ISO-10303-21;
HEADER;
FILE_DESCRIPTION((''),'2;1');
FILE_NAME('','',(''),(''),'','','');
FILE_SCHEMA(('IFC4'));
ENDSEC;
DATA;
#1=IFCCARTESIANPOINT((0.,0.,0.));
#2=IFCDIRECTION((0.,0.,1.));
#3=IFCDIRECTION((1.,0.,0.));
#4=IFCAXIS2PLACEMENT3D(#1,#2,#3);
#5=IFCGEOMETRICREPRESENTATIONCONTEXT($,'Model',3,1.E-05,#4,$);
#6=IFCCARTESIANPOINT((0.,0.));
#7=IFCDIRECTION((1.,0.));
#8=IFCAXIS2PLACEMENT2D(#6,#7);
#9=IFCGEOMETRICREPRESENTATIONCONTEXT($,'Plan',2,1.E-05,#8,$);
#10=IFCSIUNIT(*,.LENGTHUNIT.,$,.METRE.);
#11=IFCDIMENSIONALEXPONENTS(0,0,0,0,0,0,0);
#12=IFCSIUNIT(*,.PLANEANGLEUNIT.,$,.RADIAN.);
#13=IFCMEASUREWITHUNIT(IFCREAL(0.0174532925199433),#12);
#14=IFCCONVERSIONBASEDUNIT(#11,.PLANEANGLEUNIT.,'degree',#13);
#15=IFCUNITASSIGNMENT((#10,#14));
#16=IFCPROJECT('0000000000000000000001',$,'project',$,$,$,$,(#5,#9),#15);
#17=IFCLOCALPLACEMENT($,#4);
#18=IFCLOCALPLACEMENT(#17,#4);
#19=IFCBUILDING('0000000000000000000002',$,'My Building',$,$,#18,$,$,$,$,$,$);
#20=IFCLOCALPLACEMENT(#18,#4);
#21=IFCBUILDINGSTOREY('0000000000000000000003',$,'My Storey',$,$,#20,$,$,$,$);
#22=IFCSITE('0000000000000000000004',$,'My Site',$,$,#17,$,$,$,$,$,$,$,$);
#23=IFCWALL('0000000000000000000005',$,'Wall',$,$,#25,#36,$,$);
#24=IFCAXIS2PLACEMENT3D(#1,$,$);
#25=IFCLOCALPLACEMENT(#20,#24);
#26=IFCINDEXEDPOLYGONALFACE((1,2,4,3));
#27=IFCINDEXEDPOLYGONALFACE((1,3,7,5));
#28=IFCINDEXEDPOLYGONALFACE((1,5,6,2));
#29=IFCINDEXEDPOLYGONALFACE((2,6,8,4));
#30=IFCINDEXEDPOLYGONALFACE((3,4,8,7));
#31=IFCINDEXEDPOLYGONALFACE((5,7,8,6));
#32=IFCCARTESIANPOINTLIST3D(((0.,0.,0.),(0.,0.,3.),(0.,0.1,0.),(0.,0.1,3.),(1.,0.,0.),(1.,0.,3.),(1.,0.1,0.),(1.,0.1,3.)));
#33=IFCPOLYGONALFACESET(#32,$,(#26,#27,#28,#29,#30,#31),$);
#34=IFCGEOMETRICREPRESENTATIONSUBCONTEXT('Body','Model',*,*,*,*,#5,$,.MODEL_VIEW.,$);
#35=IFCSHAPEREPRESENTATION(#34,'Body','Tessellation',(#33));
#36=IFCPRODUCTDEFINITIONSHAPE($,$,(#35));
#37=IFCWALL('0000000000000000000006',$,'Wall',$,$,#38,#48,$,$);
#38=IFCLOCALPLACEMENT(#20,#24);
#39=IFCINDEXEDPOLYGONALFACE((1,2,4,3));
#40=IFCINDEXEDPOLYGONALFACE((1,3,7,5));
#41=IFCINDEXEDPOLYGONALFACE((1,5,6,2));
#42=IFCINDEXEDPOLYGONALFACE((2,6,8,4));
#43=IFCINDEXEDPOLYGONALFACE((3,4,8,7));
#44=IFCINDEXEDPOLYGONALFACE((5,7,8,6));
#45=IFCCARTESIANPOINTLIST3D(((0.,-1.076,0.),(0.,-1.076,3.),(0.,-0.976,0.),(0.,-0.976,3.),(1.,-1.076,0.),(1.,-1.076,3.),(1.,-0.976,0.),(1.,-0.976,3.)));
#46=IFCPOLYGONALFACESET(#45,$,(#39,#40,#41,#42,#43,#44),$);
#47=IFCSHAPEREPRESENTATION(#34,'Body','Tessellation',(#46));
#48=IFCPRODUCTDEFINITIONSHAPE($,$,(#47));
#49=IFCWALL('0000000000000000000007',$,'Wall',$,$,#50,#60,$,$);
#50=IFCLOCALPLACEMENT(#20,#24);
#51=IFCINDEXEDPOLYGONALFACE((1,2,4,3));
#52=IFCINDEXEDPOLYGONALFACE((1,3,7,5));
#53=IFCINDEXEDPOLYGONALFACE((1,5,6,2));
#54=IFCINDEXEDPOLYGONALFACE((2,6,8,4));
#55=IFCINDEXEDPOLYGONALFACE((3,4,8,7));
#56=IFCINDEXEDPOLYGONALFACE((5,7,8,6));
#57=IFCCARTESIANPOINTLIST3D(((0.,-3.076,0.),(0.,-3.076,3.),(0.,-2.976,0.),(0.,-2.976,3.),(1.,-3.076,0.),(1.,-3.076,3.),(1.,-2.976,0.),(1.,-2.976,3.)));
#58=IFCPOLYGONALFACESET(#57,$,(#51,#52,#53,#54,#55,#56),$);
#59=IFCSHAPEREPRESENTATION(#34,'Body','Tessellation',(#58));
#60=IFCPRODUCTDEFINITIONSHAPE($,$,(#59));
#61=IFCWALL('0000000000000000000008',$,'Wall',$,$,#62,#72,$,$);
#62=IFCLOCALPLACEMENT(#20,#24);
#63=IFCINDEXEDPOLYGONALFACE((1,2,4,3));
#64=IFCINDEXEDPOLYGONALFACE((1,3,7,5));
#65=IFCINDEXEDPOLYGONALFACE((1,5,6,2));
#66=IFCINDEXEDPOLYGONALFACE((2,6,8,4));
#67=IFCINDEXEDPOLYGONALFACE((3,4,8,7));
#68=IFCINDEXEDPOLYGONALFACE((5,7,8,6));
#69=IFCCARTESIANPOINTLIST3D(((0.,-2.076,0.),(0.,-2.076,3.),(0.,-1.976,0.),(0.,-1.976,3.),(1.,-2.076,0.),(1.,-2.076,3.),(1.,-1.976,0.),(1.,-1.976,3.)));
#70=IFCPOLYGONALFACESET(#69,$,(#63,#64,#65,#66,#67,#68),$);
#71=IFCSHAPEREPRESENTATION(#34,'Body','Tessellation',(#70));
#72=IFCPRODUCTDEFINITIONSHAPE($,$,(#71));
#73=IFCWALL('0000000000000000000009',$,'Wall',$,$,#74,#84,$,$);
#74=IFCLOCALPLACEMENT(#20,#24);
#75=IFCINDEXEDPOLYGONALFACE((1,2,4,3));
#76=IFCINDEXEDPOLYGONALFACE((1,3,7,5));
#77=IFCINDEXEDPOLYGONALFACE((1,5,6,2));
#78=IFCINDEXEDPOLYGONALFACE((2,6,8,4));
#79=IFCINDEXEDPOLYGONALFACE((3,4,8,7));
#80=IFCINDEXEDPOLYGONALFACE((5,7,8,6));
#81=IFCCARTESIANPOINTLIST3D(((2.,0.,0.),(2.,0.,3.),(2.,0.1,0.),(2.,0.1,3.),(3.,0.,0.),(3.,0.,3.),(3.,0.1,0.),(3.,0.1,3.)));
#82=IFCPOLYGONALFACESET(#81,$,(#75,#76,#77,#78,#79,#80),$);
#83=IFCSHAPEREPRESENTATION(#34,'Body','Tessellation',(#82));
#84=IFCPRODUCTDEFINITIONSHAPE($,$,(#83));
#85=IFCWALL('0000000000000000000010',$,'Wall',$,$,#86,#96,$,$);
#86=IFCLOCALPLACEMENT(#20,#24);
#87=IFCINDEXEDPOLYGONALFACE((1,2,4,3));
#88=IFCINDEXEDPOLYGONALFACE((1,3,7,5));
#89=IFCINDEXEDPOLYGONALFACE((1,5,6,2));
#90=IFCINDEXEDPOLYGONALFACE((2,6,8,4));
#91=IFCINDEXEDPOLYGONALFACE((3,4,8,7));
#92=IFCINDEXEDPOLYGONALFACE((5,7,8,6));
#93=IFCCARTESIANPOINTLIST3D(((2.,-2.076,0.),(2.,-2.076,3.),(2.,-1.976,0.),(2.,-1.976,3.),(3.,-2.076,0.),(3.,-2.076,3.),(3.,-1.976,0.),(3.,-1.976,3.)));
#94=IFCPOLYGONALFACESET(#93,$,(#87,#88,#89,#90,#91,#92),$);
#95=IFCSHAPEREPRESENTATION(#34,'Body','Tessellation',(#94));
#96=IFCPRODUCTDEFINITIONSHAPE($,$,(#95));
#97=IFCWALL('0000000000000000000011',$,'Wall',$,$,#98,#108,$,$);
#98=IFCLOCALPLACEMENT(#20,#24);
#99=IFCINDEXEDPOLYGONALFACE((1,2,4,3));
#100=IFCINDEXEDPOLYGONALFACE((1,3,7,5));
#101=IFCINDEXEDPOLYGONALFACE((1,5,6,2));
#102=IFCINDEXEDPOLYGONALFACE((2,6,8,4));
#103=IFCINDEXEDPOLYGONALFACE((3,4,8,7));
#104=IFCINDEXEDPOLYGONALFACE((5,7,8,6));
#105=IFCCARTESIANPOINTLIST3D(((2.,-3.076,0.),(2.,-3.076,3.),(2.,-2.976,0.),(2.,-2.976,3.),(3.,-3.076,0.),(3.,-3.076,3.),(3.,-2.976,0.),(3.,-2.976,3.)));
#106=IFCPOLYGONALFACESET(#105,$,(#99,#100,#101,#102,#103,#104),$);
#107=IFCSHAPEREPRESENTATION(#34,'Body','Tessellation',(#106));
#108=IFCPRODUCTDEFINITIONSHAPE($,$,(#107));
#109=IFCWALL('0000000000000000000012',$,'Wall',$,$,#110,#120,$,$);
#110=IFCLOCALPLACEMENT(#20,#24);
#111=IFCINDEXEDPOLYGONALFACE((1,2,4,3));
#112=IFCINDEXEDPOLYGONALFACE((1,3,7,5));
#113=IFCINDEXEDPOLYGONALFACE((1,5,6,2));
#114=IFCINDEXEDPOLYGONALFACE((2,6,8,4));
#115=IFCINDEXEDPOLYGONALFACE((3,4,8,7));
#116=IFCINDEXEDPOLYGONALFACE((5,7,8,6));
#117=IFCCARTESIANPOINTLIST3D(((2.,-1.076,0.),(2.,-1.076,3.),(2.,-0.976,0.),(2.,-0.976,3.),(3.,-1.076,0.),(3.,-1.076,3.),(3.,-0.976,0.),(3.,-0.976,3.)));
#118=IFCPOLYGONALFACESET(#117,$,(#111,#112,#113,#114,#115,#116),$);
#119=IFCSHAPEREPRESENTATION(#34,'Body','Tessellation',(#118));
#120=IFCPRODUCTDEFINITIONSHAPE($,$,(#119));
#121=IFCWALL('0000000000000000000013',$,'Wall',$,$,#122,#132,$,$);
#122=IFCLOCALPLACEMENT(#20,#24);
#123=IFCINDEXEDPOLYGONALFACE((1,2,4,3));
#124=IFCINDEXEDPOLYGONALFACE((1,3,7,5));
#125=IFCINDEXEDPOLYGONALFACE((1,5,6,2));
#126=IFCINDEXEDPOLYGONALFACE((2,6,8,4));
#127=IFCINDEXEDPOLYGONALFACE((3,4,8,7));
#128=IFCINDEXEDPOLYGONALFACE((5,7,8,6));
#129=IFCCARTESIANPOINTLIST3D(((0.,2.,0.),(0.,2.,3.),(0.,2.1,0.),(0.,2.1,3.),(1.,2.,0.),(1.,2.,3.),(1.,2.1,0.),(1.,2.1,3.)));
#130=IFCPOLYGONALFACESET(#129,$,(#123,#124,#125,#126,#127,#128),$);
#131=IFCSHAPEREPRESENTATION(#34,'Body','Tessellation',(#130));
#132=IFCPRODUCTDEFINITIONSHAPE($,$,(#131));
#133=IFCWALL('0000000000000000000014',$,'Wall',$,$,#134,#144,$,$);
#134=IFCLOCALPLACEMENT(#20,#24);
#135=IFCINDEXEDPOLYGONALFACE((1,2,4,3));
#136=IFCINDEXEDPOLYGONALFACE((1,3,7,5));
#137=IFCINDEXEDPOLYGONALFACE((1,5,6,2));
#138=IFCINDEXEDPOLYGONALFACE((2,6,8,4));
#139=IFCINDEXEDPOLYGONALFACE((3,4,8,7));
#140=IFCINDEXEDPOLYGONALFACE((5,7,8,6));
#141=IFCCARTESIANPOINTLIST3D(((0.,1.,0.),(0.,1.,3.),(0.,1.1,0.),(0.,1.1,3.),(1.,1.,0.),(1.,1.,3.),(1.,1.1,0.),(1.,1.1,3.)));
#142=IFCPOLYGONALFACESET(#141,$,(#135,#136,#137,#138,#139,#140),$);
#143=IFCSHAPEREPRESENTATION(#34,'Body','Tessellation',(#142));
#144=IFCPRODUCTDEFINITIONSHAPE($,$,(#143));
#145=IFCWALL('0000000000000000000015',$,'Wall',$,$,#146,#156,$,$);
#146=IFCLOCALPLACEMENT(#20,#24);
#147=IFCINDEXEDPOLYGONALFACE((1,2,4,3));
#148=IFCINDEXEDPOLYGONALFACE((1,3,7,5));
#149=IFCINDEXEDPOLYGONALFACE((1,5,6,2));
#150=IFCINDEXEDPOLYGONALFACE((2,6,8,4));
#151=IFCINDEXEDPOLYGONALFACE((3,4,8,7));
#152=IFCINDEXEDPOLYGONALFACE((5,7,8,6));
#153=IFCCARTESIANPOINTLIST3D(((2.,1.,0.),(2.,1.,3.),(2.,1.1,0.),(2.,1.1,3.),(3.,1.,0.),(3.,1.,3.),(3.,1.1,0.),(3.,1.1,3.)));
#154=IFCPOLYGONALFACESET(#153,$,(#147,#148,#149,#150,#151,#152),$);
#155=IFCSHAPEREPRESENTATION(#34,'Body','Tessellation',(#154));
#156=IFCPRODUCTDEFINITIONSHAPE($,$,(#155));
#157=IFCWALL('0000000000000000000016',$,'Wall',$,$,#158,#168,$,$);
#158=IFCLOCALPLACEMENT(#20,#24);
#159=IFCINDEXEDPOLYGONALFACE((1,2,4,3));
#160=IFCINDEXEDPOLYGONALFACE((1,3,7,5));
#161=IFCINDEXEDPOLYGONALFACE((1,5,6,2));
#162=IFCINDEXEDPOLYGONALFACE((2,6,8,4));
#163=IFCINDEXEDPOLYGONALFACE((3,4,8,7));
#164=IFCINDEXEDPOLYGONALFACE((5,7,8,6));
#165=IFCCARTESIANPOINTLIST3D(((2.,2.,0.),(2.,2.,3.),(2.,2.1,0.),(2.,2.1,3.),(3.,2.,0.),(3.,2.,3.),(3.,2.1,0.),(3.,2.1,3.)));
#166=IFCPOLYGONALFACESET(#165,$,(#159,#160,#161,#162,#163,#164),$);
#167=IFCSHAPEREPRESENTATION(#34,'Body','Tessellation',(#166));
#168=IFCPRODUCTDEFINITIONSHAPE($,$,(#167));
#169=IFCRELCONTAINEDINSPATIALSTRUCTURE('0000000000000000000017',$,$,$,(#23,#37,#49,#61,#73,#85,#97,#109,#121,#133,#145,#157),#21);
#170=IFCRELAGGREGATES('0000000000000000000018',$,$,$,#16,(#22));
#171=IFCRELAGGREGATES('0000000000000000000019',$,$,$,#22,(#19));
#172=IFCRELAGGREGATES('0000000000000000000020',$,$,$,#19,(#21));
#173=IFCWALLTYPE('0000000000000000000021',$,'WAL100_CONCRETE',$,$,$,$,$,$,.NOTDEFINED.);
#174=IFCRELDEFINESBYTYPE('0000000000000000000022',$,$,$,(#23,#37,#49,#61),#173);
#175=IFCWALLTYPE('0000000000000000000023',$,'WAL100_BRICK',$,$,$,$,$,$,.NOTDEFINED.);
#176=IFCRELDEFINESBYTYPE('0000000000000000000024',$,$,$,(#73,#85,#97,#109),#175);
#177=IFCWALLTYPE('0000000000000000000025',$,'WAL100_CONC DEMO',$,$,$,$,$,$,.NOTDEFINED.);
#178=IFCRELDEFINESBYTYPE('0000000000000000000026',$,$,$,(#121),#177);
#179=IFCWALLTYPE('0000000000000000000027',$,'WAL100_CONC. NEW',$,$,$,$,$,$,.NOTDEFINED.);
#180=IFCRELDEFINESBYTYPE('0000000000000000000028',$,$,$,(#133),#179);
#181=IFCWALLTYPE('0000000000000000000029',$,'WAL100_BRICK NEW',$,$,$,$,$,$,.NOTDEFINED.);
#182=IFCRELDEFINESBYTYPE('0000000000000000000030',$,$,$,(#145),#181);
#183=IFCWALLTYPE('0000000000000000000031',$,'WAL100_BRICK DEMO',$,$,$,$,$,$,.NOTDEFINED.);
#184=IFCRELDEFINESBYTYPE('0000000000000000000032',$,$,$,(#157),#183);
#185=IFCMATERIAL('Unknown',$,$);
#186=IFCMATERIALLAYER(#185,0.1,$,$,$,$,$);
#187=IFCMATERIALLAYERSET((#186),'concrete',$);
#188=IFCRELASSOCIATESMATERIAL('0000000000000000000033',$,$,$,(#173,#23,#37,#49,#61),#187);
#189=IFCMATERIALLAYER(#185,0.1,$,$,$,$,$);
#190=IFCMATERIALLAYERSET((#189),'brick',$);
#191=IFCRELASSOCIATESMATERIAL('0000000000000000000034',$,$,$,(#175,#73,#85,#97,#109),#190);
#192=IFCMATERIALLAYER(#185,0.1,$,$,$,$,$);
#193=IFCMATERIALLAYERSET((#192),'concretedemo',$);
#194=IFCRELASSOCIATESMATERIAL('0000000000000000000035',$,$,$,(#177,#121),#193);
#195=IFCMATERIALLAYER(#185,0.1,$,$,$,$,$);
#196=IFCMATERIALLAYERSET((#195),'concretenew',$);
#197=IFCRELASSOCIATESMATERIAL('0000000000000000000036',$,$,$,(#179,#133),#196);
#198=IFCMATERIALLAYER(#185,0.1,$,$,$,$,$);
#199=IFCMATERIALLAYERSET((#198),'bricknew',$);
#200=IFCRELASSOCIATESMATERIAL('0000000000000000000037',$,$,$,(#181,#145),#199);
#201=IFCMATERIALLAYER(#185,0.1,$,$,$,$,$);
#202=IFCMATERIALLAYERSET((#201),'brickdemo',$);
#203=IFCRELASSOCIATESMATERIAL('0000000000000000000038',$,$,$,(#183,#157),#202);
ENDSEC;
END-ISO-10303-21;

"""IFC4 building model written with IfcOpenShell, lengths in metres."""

from ifc_helpers import new_model, entity, si_unit, converted_unit, frame, origin_with_axes, origin_2d_with_axis, place, context, subcontext, project, spatial, indexed_curve, outline, extrude, material, layer, layer_set, layer_usage, type_object, element, save


model = new_model("IFC4")

# Units and contexts
model_context = context("Model", 3, precision=1e-05, world=origin_with_axes())
plan_context = context("Plan", 2, precision=1e-05, world=origin_2d_with_axis())
body_context = subcontext(model_context, "Body", "Model", "MODEL_VIEW")
ifc_project = project(units=[si_unit("LENGTHUNIT", "METRE"), converted_unit("PLANEANGLEUNIT", "degree", entity("IfcReal", 0.0174532925199433), si_unit("PLANEANGLEUNIT", "RADIAN"), dimensions=[0, 0, 0, 0, 0, 0, 0])], contexts=[model_context, plan_context])

# Site, building, storey
site_placement = place(None, origin_with_axes())
site = spatial("IfcSite", under=ifc_project, at=site_placement, Name="My Site")
building_placement = place(site_placement, origin_with_axes())
building = spatial("IfcBuilding", under=site, at=building_placement, Name="My Building")
storey_placement = place(building_placement, origin_with_axes())
storey = spatial("IfcBuildingStorey", under=building, at=storey_placement, Name="My Storey")

# Walls
ifc_material = material(Name="Unknown")
ifc_layer_1 = layer(ifc_material, 0.1)
ifc_layer_set_1 = layer_set([ifc_layer_1], Name="concrete")
ifc_layer_usage_1 = layer_usage(ifc_layer_set_1, "AXIS2", "POSITIVE", 0.0)
wall_type_1 = type_object("IfcWallType", Name="WAL100_CONCRETE", PredefinedType="NOTDEFINED", material=ifc_layer_set_1)
wall_1_placement = place(storey_placement, origin_with_axes())
element("IfcWall", 1, at=wall_1_placement, inside=storey, type_object=wall_type_1, material=ifc_layer_usage_1, Name="Wall", context=body_context, shape_type="SweptSolid", body=[
    extrude(outline(indexed_curve([(0.0, 0.0), (0.0, 0.1), (1.0, 0.1), (1.0, 0.0), (0.0, 0.0)], self_intersect=False)), origin_with_axes(), (0.0, 0.0, 1.0), 3.0),
])
ifc_layer_usage_2 = layer_usage(ifc_layer_set_1, "AXIS2", "POSITIVE", 0.0)
wall_2_placement = place(storey_placement, frame((0.0, -1.076, 0.0), z_axis=(0.0, 0.0, 1.0), x_axis=(1.0, 0.0, 0.0)))
element("IfcWall", 2, at=wall_2_placement, inside=storey, type_object=wall_type_1, material=ifc_layer_usage_2, Name="Wall", context=body_context, shape_type="SweptSolid", body=[
    extrude(outline(indexed_curve([(0.0, 0.0), (0.0, 0.1), (1.0, 0.1), (1.0, 0.0), (0.0, 0.0)], self_intersect=False)), origin_with_axes(), (0.0, 0.0, 1.0), 3.0),
])
ifc_layer_usage_3 = layer_usage(ifc_layer_set_1, "AXIS2", "POSITIVE", 0.0)
wall_3_placement = place(storey_placement, frame((0.0, -3.076, 0.0), z_axis=(0.0, 0.0, 1.0), x_axis=(1.0, 0.0, 0.0)))
element("IfcWall", 3, at=wall_3_placement, inside=storey, type_object=wall_type_1, material=ifc_layer_usage_3, Name="Wall", context=body_context, shape_type="SweptSolid", body=[
    extrude(outline(indexed_curve([(0.0, 0.0), (0.0, 0.1), (1.0, 0.1), (1.0, 0.0), (0.0, 0.0)], self_intersect=False)), origin_with_axes(), (0.0, 0.0, 1.0), 3.0),
])
ifc_layer_usage_4 = layer_usage(ifc_layer_set_1, "AXIS2", "POSITIVE", 0.0)
wall_4_placement = place(storey_placement, frame((0.0, -2.076, 0.0), z_axis=(0.0, 0.0, 1.0), x_axis=(1.0, 0.0, 0.0)))
element("IfcWall", 4, at=wall_4_placement, inside=storey, type_object=wall_type_1, material=ifc_layer_usage_4, Name="Wall", context=body_context, shape_type="SweptSolid", body=[
    extrude(outline(indexed_curve([(0.0, 0.0), (0.0, 0.1), (1.0, 0.1), (1.0, 0.0), (0.0, 0.0)], self_intersect=False)), origin_with_axes(), (0.0, 0.0, 1.0), 3.0),
])
ifc_layer_2 = layer(ifc_material, 0.1)
ifc_layer_set_2 = layer_set([ifc_layer_2], Name="brick")
ifc_layer_usage_5 = layer_usage(ifc_layer_set_2, "AXIS2", "POSITIVE", 0.0)
wall_type_2 = type_object("IfcWallType", Name="WAL100_BRICK", PredefinedType="NOTDEFINED", material=ifc_layer_set_2)
wall_5_placement = place(storey_placement, frame((2.0, 0.0, 0.0), z_axis=(0.0, 0.0, 1.0), x_axis=(1.0, 0.0, 0.0)))
element("IfcWall", 5, at=wall_5_placement, inside=storey, type_object=wall_type_2, material=ifc_layer_usage_5, Name="Wall", context=body_context, shape_type="SweptSolid", body=[
    extrude(outline(indexed_curve([(0.0, 0.0), (0.0, 0.1), (1.0, 0.1), (1.0, 0.0), (0.0, 0.0)], self_intersect=False)), origin_with_axes(), (0.0, 0.0, 1.0), 3.0),
])
ifc_layer_usage_6 = layer_usage(ifc_layer_set_2, "AXIS2", "POSITIVE", 0.0)
wall_6_placement = place(storey_placement, frame((2.0, -2.076, 0.0), z_axis=(0.0, 0.0, 1.0), x_axis=(1.0, 0.0, 0.0)))
element("IfcWall", 6, at=wall_6_placement, inside=storey, type_object=wall_type_2, material=ifc_layer_usage_6, Name="Wall", context=body_context, shape_type="SweptSolid", body=[
    extrude(outline(indexed_curve([(0.0, 0.0), (0.0, 0.1), (1.0, 0.1), (1.0, 0.0), (0.0, 0.0)], self_intersect=False)), origin_with_axes(), (0.0, 0.0, 1.0), 3.0),
])
ifc_layer_usage_7 = layer_usage(ifc_layer_set_2, "AXIS2", "POSITIVE", 0.0)
wall_7_placement = place(storey_placement, frame((2.0, -3.076, 0.0), z_axis=(0.0, 0.0, 1.0), x_axis=(1.0, 0.0, 0.0)))
element("IfcWall", 7, at=wall_7_placement, inside=storey, type_object=wall_type_2, material=ifc_layer_usage_7, Name="Wall", context=body_context, shape_type="SweptSolid", body=[
    extrude(outline(indexed_curve([(0.0, 0.0), (0.0, 0.1), (1.0, 0.1), (1.0, 0.0), (0.0, 0.0)], self_intersect=False)), origin_with_axes(), (0.0, 0.0, 1.0), 3.0),
])
ifc_layer_usage_8 = layer_usage(ifc_layer_set_2, "AXIS2", "POSITIVE", 0.0)
wall_8_placement = place(storey_placement, frame((2.0, -1.076, 0.0), z_axis=(0.0, 0.0, 1.0), x_axis=(1.0, 0.0, 0.0)))
element("IfcWall", 8, at=wall_8_placement, inside=storey, type_object=wall_type_2, material=ifc_layer_usage_8, Name="Wall", context=body_context, shape_type="SweptSolid", body=[
    extrude(outline(indexed_curve([(0.0, 0.0), (0.0, 0.1), (1.0, 0.1), (1.0, 0.0), (0.0, 0.0)], self_intersect=False)), origin_with_axes(), (0.0, 0.0, 1.0), 3.0),
])
ifc_layer_3 = layer(ifc_material, 0.1)
ifc_layer_set_3 = layer_set([ifc_layer_3], Name="concretedemo")
ifc_layer_usage_9 = layer_usage(ifc_layer_set_3, "AXIS2", "POSITIVE", 0.0)
wall_type_3 = type_object("IfcWallType", Name="WAL100_CONC DEMO", PredefinedType="NOTDEFINED", material=ifc_layer_set_3)
wall_9_placement = place(storey_placement, frame((0.0, 2.0, 0.0), z_axis=(0.0, 0.0, 1.0), x_axis=(1.0, 0.0, 0.0)))
element("IfcWall", 9, at=wall_9_placement, inside=storey, type_object=wall_type_3, material=ifc_layer_usage_9, Name="Wall", context=body_context, shape_type="SweptSolid", body=[
    extrude(outline(indexed_curve([(0.0, 0.0), (0.0, 0.1), (1.0, 0.1), (1.0, 0.0), (0.0, 0.0)], self_intersect=False)), origin_with_axes(), (0.0, 0.0, 1.0), 3.0),
])
ifc_layer_4 = layer(ifc_material, 0.1)
ifc_layer_set_4 = layer_set([ifc_layer_4], Name="concretenew")
ifc_layer_usage_10 = layer_usage(ifc_layer_set_4, "AXIS2", "POSITIVE", 0.0)
wall_type_4 = type_object("IfcWallType", Name="WAL100_CONC. NEW", PredefinedType="NOTDEFINED", material=ifc_layer_set_4)
wall_10_placement = place(storey_placement, frame((0.0, 1.0, 0.0), z_axis=(0.0, 0.0, 1.0), x_axis=(1.0, 0.0, 0.0)))
element("IfcWall", 10, at=wall_10_placement, inside=storey, type_object=wall_type_4, material=ifc_layer_usage_10, Name="Wall", context=body_context, shape_type="SweptSolid", body=[
    extrude(outline(indexed_curve([(0.0, 0.0), (0.0, 0.1), (1.0, 0.1), (1.0, 0.0), (0.0, 0.0)], self_intersect=False)), origin_with_axes(), (0.0, 0.0, 1.0), 3.0),
])
ifc_layer_5 = layer(ifc_material, 0.1)
ifc_layer_set_5 = layer_set([ifc_layer_5], Name="bricknew")
ifc_layer_usage_11 = layer_usage(ifc_layer_set_5, "AXIS2", "POSITIVE", 0.0)
wall_type_5 = type_object("IfcWallType", Name="WAL100_BRICK NEW", PredefinedType="NOTDEFINED", material=ifc_layer_set_5)
wall_11_placement = place(storey_placement, frame((2.0, 1.0, 0.0), z_axis=(0.0, 0.0, 1.0), x_axis=(1.0, 0.0, 0.0)))
element("IfcWall", 11, at=wall_11_placement, inside=storey, type_object=wall_type_5, material=ifc_layer_usage_11, Name="Wall", context=body_context, shape_type="SweptSolid", body=[
    extrude(outline(indexed_curve([(0.0, 0.0), (0.0, 0.1), (1.0, 0.1), (1.0, 0.0), (0.0, 0.0)], self_intersect=False)), origin_with_axes(), (0.0, 0.0, 1.0), 3.0),
])
ifc_layer_6 = layer(ifc_material, 0.1)
ifc_layer_set_6 = layer_set([ifc_layer_6], Name="brickdemo")
ifc_layer_usage_12 = layer_usage(ifc_layer_set_6, "AXIS2", "POSITIVE", 0.0)
wall_type_6 = type_object("IfcWallType", Name="WAL100_BRICK DEMO", PredefinedType="NOTDEFINED", material=ifc_layer_set_6)
wall_12_placement = place(storey_placement, frame((2.0, 2.0, 0.0), z_axis=(0.0, 0.0, 1.0), x_axis=(1.0, 0.0, 0.0)))
element("IfcWall", 12, at=wall_12_placement, inside=storey, type_object=wall_type_6, material=ifc_layer_usage_12, Name="Wall", context=body_context, shape_type="SweptSolid", body=[
    extrude(outline(indexed_curve([(0.0, 0.0), (0.0, 0.1), (1.0, 0.1), (1.0, 0.0), (0.0, 0.0)], self_intersect=False)), origin_with_axes(), (0.0, 0.0, 1.0), 3.0),
])

save(model, "model.ifc")
